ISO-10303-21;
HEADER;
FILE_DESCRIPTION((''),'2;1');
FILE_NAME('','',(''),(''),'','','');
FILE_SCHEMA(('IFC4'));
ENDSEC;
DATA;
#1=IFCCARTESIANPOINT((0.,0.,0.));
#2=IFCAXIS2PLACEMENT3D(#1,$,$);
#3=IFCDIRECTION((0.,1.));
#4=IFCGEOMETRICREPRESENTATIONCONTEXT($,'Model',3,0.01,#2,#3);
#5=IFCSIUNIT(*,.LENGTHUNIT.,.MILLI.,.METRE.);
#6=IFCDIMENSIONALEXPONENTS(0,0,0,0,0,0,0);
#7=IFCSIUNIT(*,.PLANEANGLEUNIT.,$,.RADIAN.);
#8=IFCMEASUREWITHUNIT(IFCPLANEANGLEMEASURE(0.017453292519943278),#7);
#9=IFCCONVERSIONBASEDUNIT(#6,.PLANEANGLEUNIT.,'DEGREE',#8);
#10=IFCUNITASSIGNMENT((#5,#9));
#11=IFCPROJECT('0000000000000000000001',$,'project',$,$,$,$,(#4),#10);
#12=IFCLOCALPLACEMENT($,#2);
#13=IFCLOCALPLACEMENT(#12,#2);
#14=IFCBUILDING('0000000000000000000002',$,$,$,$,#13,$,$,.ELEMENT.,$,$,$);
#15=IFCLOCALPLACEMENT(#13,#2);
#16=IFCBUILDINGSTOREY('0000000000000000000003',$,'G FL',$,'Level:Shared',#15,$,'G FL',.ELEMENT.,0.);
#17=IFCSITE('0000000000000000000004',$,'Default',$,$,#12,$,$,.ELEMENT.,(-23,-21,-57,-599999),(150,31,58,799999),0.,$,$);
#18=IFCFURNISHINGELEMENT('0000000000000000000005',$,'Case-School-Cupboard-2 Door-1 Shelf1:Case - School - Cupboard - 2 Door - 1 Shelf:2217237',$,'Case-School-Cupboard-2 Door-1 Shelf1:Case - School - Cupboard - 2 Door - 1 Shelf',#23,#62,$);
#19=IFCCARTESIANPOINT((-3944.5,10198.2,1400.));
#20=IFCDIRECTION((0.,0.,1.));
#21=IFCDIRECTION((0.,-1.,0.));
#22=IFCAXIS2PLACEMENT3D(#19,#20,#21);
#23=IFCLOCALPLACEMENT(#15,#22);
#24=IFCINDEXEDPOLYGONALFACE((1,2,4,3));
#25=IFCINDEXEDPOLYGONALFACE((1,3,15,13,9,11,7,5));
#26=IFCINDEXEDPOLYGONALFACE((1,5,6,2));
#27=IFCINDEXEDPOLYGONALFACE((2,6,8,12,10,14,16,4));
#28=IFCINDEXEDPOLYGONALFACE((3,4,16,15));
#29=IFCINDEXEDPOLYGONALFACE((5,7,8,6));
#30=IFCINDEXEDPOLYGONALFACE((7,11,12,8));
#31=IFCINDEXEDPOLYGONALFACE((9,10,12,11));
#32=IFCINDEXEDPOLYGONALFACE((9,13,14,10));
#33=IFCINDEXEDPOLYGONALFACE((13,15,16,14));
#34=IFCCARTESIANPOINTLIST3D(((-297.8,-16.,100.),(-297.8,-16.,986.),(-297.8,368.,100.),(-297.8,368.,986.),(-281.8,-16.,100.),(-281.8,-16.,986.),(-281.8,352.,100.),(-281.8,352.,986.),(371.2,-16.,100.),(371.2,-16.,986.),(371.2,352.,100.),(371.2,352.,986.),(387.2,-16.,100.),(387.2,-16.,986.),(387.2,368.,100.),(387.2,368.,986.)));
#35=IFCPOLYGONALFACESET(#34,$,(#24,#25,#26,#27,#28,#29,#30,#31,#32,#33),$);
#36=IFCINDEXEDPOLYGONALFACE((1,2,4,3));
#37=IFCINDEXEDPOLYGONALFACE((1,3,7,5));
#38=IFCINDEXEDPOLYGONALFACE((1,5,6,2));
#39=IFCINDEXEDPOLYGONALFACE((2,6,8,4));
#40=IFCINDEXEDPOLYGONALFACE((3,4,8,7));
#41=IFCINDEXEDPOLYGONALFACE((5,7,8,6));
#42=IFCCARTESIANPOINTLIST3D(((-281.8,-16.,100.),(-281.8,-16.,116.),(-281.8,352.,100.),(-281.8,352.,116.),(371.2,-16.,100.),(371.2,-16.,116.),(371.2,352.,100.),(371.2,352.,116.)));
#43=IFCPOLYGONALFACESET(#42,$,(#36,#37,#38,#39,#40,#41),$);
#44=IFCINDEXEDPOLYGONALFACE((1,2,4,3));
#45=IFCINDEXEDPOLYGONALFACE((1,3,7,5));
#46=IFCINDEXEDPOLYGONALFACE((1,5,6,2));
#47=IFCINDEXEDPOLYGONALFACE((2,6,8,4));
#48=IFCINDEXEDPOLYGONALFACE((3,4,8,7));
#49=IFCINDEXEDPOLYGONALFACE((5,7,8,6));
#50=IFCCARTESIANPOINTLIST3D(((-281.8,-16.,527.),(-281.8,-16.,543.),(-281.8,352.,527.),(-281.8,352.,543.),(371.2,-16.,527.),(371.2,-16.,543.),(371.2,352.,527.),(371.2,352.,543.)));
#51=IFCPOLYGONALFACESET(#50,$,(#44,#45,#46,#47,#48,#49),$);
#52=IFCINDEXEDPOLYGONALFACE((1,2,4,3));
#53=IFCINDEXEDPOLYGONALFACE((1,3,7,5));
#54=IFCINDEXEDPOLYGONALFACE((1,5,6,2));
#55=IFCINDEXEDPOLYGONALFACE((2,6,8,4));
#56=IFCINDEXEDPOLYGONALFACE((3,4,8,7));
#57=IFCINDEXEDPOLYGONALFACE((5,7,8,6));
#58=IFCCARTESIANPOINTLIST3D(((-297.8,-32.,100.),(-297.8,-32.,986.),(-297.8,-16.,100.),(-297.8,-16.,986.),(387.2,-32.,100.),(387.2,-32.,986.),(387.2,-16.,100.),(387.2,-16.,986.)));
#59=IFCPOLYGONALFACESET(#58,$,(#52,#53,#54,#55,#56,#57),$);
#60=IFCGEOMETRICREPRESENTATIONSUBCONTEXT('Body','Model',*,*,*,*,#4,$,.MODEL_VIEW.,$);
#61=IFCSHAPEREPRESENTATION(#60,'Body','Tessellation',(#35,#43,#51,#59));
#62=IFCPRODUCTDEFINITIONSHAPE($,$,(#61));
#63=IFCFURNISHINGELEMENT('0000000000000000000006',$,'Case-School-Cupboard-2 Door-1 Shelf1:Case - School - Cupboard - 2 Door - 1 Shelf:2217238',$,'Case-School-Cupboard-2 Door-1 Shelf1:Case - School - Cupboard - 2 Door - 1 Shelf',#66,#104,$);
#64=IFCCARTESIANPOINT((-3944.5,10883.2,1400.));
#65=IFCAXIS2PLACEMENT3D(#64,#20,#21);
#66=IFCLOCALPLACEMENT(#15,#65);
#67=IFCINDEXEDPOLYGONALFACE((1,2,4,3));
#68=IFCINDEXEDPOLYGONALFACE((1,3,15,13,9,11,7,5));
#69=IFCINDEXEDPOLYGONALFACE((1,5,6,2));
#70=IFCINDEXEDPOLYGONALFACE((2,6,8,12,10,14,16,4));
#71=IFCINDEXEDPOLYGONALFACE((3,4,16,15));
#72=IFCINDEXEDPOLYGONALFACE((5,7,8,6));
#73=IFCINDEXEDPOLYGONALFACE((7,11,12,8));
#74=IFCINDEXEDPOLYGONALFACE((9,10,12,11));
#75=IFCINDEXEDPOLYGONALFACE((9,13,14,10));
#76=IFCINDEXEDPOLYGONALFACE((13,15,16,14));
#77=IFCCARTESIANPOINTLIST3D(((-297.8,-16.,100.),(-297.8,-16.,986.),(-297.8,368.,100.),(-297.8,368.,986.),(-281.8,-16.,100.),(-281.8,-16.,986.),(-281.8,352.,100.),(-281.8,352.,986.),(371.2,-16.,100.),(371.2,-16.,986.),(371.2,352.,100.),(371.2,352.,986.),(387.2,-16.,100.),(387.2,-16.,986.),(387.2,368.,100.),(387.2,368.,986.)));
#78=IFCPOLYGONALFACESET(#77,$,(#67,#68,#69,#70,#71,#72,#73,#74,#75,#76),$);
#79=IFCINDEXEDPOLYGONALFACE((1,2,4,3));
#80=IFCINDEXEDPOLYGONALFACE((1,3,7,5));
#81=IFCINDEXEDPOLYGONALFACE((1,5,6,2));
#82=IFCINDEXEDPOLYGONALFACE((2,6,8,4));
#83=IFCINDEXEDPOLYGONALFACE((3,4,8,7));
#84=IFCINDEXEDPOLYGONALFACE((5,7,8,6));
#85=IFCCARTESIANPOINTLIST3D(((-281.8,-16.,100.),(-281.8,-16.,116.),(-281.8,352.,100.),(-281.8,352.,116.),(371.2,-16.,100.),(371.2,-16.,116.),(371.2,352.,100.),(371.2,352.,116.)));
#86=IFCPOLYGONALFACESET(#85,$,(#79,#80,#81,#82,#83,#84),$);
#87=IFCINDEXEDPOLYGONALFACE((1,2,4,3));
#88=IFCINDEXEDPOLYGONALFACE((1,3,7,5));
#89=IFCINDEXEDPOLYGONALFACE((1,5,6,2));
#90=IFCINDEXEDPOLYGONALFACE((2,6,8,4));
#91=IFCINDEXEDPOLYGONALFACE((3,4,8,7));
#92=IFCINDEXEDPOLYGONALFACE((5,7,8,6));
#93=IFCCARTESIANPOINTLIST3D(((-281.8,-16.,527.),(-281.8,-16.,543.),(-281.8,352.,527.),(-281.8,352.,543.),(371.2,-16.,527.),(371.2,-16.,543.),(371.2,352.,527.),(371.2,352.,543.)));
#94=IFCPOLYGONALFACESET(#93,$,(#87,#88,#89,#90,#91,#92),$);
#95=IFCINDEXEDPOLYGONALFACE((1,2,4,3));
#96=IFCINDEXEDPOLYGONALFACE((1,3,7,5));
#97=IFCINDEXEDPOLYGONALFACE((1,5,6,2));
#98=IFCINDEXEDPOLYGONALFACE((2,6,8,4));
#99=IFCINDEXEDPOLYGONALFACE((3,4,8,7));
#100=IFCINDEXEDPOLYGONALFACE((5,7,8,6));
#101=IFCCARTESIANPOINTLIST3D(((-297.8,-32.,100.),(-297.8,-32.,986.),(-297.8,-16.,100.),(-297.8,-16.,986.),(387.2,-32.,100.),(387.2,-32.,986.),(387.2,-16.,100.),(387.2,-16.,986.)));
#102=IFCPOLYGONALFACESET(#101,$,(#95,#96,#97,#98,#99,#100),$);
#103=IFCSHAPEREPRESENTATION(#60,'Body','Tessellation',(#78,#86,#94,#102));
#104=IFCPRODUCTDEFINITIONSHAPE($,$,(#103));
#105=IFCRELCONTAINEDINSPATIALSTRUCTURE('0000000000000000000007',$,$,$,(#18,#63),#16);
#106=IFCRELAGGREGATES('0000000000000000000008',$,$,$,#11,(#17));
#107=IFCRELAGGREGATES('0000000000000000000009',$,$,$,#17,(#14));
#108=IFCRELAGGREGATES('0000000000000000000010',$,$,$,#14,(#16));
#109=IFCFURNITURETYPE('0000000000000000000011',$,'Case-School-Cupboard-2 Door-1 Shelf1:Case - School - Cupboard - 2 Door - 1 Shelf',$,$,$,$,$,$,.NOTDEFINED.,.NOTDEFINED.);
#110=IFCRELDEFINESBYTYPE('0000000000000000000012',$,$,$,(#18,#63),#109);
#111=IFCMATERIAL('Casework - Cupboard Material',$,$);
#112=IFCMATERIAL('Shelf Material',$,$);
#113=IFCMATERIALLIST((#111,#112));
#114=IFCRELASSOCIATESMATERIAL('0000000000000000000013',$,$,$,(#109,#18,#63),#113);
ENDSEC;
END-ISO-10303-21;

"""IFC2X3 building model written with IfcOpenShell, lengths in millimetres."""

from ifc_helpers import new_model, entity, si_unit, converted_unit, direction, frame, frame_2d, origin, origin_2d_with_axis, place, context, subcontext, project, spatial, polyline, rectangle, outline, extrude, source, transform, mapped, material, material_list, type_object, type_shapes, element, save


model = new_model("IFC2X3")

# Units and contexts
model_context = context("Model", 3, precision=0.01, world=origin(), true_north=direction((0.0, 1.0)))
body_context = subcontext(model_context, "Body", "Model", "MODEL_VIEW")
ifc_project = project(units=[si_unit("LENGTHUNIT", "METRE", prefix="MILLI"), converted_unit("PLANEANGLEUNIT", "DEGREE", entity("IfcPlaneAngleMeasure", 0.017453292519943278), si_unit("PLANEANGLEUNIT", "RADIAN"), dimensions=[0, 0, 0, 0, 0, 0, 0])], contexts=[model_context])

# Site, building, storey
site_placement = place(None, origin())
site = spatial("IfcSite", under=ifc_project, at=site_placement, Name="Default", CompositionType="ELEMENT", RefLatitude=(-23, -21, -57, -599999), RefLongitude=(150, 31, 58, 799999), RefElevation=0.0)
building_placement = place(site_placement, origin())
building = spatial("IfcBuilding", under=site, at=building_placement, CompositionType="ELEMENT")
storey_placement = place(building_placement, origin())
storey = spatial("IfcBuildingStorey", under=building, at=storey_placement, Name="G FL", ObjectType="Level:Shared", LongName="G FL", CompositionType="ELEMENT", Elevation=0.0)

# Furnishing elements
ifc_material_1 = material(Name="Casework - Cupboard Material")
ifc_material_2 = material(Name="Shelf Material")
ifc_material_list = material_list([ifc_material_1, ifc_material_2])
furniture_type = type_object("IfcFurnitureType", Name="Case-School-Cupboard-2 Door-1 Shelf1:Case - School - Cupboard - 2 Door - 1 Shelf", AssemblyPlace="NOTDEFINED", material=ifc_material_list)
shared_shape = source(origin(), body_context, "Body", "SweptSolid", [
    extrude(outline(polyline([(-188.0, -326.5), (-188.0, -342.5), (196.0, -342.5), (196.0, 342.5), (-188.0, 342.5), (-188.0, 326.5), (180.0, 326.5), (180.0, -326.5), (-188.0, -326.5)])), frame((44.7, 172.0, 100.0), z_axis=(0.0, 0.0, -1.0), x_axis=(0.0, 1.0, 0.0)), (0.0, 0.0, -1.0), 886.0),
    extrude(rectangle(XDim=653.0, YDim=368.0, at=frame_2d((0.0, 0.0), x_axis=(1.0, 0.0))), frame((44.7, 168.0, 100.0)), (0.0, 0.0, 1.0), 16.0),
    extrude(rectangle(XDim=368.0, YDim=653.0, at=origin_2d_with_axis()), frame((44.7, 168.0, 527.0), z_axis=(0.0, 0.0, 1.0), x_axis=(0.0, -1.0, 0.0)), (0.0, 0.0, 1.0), 16.0),
    extrude(rectangle(XDim=16.0, YDim=685.0, at=frame_2d((0.0, 0.0), x_axis=(1.0, 0.0))), frame((44.7, -24.0, 100.0), z_axis=(0.0, 0.0, 1.0), x_axis=(0.0, -1.0, 0.0)), (0.0, 0.0, 1.0), 886.0),
])
type_shapes(furniture_type, [shared_shape])
for number, where, z_axis, x_axis, name in (
    (1, (-3944.5, 10198.2, 1400.0), (0.0, 0.0, 1.0), (0.0, -1.0, 0.0), "Case-School-Cupboard-2 Door-1 Shelf1:Case - School - Cupboard - 2 Door - 1 Shelf:2217237"),
    (2, (-3944.5, 10883.2, 1400.0), (0.0, 0.0, 1.0), (0.0, -1.0, 0.0), "Case-School-Cupboard-2 Door-1 Shelf1:Case - School - Cupboard - 2 Door - 1 Shelf:2217238"),
):
    element("IfcFurnishingElement", number, at=place(storey_placement, frame(where, z_axis=z_axis, x_axis=x_axis)), inside=storey, type_object=furniture_type, material=ifc_material_list, Name=name, ObjectType="Case-School-Cupboard-2 Door-1 Shelf1:Case - School - Cupboard - 2 Door - 1 Shelf", context=body_context, shape_type="MappedRepresentation", body=[
        mapped(shared_shape, transform((0.0, 0.0, 0.0), scale=1.0)),
    ])

save(model, "model.ifc")
